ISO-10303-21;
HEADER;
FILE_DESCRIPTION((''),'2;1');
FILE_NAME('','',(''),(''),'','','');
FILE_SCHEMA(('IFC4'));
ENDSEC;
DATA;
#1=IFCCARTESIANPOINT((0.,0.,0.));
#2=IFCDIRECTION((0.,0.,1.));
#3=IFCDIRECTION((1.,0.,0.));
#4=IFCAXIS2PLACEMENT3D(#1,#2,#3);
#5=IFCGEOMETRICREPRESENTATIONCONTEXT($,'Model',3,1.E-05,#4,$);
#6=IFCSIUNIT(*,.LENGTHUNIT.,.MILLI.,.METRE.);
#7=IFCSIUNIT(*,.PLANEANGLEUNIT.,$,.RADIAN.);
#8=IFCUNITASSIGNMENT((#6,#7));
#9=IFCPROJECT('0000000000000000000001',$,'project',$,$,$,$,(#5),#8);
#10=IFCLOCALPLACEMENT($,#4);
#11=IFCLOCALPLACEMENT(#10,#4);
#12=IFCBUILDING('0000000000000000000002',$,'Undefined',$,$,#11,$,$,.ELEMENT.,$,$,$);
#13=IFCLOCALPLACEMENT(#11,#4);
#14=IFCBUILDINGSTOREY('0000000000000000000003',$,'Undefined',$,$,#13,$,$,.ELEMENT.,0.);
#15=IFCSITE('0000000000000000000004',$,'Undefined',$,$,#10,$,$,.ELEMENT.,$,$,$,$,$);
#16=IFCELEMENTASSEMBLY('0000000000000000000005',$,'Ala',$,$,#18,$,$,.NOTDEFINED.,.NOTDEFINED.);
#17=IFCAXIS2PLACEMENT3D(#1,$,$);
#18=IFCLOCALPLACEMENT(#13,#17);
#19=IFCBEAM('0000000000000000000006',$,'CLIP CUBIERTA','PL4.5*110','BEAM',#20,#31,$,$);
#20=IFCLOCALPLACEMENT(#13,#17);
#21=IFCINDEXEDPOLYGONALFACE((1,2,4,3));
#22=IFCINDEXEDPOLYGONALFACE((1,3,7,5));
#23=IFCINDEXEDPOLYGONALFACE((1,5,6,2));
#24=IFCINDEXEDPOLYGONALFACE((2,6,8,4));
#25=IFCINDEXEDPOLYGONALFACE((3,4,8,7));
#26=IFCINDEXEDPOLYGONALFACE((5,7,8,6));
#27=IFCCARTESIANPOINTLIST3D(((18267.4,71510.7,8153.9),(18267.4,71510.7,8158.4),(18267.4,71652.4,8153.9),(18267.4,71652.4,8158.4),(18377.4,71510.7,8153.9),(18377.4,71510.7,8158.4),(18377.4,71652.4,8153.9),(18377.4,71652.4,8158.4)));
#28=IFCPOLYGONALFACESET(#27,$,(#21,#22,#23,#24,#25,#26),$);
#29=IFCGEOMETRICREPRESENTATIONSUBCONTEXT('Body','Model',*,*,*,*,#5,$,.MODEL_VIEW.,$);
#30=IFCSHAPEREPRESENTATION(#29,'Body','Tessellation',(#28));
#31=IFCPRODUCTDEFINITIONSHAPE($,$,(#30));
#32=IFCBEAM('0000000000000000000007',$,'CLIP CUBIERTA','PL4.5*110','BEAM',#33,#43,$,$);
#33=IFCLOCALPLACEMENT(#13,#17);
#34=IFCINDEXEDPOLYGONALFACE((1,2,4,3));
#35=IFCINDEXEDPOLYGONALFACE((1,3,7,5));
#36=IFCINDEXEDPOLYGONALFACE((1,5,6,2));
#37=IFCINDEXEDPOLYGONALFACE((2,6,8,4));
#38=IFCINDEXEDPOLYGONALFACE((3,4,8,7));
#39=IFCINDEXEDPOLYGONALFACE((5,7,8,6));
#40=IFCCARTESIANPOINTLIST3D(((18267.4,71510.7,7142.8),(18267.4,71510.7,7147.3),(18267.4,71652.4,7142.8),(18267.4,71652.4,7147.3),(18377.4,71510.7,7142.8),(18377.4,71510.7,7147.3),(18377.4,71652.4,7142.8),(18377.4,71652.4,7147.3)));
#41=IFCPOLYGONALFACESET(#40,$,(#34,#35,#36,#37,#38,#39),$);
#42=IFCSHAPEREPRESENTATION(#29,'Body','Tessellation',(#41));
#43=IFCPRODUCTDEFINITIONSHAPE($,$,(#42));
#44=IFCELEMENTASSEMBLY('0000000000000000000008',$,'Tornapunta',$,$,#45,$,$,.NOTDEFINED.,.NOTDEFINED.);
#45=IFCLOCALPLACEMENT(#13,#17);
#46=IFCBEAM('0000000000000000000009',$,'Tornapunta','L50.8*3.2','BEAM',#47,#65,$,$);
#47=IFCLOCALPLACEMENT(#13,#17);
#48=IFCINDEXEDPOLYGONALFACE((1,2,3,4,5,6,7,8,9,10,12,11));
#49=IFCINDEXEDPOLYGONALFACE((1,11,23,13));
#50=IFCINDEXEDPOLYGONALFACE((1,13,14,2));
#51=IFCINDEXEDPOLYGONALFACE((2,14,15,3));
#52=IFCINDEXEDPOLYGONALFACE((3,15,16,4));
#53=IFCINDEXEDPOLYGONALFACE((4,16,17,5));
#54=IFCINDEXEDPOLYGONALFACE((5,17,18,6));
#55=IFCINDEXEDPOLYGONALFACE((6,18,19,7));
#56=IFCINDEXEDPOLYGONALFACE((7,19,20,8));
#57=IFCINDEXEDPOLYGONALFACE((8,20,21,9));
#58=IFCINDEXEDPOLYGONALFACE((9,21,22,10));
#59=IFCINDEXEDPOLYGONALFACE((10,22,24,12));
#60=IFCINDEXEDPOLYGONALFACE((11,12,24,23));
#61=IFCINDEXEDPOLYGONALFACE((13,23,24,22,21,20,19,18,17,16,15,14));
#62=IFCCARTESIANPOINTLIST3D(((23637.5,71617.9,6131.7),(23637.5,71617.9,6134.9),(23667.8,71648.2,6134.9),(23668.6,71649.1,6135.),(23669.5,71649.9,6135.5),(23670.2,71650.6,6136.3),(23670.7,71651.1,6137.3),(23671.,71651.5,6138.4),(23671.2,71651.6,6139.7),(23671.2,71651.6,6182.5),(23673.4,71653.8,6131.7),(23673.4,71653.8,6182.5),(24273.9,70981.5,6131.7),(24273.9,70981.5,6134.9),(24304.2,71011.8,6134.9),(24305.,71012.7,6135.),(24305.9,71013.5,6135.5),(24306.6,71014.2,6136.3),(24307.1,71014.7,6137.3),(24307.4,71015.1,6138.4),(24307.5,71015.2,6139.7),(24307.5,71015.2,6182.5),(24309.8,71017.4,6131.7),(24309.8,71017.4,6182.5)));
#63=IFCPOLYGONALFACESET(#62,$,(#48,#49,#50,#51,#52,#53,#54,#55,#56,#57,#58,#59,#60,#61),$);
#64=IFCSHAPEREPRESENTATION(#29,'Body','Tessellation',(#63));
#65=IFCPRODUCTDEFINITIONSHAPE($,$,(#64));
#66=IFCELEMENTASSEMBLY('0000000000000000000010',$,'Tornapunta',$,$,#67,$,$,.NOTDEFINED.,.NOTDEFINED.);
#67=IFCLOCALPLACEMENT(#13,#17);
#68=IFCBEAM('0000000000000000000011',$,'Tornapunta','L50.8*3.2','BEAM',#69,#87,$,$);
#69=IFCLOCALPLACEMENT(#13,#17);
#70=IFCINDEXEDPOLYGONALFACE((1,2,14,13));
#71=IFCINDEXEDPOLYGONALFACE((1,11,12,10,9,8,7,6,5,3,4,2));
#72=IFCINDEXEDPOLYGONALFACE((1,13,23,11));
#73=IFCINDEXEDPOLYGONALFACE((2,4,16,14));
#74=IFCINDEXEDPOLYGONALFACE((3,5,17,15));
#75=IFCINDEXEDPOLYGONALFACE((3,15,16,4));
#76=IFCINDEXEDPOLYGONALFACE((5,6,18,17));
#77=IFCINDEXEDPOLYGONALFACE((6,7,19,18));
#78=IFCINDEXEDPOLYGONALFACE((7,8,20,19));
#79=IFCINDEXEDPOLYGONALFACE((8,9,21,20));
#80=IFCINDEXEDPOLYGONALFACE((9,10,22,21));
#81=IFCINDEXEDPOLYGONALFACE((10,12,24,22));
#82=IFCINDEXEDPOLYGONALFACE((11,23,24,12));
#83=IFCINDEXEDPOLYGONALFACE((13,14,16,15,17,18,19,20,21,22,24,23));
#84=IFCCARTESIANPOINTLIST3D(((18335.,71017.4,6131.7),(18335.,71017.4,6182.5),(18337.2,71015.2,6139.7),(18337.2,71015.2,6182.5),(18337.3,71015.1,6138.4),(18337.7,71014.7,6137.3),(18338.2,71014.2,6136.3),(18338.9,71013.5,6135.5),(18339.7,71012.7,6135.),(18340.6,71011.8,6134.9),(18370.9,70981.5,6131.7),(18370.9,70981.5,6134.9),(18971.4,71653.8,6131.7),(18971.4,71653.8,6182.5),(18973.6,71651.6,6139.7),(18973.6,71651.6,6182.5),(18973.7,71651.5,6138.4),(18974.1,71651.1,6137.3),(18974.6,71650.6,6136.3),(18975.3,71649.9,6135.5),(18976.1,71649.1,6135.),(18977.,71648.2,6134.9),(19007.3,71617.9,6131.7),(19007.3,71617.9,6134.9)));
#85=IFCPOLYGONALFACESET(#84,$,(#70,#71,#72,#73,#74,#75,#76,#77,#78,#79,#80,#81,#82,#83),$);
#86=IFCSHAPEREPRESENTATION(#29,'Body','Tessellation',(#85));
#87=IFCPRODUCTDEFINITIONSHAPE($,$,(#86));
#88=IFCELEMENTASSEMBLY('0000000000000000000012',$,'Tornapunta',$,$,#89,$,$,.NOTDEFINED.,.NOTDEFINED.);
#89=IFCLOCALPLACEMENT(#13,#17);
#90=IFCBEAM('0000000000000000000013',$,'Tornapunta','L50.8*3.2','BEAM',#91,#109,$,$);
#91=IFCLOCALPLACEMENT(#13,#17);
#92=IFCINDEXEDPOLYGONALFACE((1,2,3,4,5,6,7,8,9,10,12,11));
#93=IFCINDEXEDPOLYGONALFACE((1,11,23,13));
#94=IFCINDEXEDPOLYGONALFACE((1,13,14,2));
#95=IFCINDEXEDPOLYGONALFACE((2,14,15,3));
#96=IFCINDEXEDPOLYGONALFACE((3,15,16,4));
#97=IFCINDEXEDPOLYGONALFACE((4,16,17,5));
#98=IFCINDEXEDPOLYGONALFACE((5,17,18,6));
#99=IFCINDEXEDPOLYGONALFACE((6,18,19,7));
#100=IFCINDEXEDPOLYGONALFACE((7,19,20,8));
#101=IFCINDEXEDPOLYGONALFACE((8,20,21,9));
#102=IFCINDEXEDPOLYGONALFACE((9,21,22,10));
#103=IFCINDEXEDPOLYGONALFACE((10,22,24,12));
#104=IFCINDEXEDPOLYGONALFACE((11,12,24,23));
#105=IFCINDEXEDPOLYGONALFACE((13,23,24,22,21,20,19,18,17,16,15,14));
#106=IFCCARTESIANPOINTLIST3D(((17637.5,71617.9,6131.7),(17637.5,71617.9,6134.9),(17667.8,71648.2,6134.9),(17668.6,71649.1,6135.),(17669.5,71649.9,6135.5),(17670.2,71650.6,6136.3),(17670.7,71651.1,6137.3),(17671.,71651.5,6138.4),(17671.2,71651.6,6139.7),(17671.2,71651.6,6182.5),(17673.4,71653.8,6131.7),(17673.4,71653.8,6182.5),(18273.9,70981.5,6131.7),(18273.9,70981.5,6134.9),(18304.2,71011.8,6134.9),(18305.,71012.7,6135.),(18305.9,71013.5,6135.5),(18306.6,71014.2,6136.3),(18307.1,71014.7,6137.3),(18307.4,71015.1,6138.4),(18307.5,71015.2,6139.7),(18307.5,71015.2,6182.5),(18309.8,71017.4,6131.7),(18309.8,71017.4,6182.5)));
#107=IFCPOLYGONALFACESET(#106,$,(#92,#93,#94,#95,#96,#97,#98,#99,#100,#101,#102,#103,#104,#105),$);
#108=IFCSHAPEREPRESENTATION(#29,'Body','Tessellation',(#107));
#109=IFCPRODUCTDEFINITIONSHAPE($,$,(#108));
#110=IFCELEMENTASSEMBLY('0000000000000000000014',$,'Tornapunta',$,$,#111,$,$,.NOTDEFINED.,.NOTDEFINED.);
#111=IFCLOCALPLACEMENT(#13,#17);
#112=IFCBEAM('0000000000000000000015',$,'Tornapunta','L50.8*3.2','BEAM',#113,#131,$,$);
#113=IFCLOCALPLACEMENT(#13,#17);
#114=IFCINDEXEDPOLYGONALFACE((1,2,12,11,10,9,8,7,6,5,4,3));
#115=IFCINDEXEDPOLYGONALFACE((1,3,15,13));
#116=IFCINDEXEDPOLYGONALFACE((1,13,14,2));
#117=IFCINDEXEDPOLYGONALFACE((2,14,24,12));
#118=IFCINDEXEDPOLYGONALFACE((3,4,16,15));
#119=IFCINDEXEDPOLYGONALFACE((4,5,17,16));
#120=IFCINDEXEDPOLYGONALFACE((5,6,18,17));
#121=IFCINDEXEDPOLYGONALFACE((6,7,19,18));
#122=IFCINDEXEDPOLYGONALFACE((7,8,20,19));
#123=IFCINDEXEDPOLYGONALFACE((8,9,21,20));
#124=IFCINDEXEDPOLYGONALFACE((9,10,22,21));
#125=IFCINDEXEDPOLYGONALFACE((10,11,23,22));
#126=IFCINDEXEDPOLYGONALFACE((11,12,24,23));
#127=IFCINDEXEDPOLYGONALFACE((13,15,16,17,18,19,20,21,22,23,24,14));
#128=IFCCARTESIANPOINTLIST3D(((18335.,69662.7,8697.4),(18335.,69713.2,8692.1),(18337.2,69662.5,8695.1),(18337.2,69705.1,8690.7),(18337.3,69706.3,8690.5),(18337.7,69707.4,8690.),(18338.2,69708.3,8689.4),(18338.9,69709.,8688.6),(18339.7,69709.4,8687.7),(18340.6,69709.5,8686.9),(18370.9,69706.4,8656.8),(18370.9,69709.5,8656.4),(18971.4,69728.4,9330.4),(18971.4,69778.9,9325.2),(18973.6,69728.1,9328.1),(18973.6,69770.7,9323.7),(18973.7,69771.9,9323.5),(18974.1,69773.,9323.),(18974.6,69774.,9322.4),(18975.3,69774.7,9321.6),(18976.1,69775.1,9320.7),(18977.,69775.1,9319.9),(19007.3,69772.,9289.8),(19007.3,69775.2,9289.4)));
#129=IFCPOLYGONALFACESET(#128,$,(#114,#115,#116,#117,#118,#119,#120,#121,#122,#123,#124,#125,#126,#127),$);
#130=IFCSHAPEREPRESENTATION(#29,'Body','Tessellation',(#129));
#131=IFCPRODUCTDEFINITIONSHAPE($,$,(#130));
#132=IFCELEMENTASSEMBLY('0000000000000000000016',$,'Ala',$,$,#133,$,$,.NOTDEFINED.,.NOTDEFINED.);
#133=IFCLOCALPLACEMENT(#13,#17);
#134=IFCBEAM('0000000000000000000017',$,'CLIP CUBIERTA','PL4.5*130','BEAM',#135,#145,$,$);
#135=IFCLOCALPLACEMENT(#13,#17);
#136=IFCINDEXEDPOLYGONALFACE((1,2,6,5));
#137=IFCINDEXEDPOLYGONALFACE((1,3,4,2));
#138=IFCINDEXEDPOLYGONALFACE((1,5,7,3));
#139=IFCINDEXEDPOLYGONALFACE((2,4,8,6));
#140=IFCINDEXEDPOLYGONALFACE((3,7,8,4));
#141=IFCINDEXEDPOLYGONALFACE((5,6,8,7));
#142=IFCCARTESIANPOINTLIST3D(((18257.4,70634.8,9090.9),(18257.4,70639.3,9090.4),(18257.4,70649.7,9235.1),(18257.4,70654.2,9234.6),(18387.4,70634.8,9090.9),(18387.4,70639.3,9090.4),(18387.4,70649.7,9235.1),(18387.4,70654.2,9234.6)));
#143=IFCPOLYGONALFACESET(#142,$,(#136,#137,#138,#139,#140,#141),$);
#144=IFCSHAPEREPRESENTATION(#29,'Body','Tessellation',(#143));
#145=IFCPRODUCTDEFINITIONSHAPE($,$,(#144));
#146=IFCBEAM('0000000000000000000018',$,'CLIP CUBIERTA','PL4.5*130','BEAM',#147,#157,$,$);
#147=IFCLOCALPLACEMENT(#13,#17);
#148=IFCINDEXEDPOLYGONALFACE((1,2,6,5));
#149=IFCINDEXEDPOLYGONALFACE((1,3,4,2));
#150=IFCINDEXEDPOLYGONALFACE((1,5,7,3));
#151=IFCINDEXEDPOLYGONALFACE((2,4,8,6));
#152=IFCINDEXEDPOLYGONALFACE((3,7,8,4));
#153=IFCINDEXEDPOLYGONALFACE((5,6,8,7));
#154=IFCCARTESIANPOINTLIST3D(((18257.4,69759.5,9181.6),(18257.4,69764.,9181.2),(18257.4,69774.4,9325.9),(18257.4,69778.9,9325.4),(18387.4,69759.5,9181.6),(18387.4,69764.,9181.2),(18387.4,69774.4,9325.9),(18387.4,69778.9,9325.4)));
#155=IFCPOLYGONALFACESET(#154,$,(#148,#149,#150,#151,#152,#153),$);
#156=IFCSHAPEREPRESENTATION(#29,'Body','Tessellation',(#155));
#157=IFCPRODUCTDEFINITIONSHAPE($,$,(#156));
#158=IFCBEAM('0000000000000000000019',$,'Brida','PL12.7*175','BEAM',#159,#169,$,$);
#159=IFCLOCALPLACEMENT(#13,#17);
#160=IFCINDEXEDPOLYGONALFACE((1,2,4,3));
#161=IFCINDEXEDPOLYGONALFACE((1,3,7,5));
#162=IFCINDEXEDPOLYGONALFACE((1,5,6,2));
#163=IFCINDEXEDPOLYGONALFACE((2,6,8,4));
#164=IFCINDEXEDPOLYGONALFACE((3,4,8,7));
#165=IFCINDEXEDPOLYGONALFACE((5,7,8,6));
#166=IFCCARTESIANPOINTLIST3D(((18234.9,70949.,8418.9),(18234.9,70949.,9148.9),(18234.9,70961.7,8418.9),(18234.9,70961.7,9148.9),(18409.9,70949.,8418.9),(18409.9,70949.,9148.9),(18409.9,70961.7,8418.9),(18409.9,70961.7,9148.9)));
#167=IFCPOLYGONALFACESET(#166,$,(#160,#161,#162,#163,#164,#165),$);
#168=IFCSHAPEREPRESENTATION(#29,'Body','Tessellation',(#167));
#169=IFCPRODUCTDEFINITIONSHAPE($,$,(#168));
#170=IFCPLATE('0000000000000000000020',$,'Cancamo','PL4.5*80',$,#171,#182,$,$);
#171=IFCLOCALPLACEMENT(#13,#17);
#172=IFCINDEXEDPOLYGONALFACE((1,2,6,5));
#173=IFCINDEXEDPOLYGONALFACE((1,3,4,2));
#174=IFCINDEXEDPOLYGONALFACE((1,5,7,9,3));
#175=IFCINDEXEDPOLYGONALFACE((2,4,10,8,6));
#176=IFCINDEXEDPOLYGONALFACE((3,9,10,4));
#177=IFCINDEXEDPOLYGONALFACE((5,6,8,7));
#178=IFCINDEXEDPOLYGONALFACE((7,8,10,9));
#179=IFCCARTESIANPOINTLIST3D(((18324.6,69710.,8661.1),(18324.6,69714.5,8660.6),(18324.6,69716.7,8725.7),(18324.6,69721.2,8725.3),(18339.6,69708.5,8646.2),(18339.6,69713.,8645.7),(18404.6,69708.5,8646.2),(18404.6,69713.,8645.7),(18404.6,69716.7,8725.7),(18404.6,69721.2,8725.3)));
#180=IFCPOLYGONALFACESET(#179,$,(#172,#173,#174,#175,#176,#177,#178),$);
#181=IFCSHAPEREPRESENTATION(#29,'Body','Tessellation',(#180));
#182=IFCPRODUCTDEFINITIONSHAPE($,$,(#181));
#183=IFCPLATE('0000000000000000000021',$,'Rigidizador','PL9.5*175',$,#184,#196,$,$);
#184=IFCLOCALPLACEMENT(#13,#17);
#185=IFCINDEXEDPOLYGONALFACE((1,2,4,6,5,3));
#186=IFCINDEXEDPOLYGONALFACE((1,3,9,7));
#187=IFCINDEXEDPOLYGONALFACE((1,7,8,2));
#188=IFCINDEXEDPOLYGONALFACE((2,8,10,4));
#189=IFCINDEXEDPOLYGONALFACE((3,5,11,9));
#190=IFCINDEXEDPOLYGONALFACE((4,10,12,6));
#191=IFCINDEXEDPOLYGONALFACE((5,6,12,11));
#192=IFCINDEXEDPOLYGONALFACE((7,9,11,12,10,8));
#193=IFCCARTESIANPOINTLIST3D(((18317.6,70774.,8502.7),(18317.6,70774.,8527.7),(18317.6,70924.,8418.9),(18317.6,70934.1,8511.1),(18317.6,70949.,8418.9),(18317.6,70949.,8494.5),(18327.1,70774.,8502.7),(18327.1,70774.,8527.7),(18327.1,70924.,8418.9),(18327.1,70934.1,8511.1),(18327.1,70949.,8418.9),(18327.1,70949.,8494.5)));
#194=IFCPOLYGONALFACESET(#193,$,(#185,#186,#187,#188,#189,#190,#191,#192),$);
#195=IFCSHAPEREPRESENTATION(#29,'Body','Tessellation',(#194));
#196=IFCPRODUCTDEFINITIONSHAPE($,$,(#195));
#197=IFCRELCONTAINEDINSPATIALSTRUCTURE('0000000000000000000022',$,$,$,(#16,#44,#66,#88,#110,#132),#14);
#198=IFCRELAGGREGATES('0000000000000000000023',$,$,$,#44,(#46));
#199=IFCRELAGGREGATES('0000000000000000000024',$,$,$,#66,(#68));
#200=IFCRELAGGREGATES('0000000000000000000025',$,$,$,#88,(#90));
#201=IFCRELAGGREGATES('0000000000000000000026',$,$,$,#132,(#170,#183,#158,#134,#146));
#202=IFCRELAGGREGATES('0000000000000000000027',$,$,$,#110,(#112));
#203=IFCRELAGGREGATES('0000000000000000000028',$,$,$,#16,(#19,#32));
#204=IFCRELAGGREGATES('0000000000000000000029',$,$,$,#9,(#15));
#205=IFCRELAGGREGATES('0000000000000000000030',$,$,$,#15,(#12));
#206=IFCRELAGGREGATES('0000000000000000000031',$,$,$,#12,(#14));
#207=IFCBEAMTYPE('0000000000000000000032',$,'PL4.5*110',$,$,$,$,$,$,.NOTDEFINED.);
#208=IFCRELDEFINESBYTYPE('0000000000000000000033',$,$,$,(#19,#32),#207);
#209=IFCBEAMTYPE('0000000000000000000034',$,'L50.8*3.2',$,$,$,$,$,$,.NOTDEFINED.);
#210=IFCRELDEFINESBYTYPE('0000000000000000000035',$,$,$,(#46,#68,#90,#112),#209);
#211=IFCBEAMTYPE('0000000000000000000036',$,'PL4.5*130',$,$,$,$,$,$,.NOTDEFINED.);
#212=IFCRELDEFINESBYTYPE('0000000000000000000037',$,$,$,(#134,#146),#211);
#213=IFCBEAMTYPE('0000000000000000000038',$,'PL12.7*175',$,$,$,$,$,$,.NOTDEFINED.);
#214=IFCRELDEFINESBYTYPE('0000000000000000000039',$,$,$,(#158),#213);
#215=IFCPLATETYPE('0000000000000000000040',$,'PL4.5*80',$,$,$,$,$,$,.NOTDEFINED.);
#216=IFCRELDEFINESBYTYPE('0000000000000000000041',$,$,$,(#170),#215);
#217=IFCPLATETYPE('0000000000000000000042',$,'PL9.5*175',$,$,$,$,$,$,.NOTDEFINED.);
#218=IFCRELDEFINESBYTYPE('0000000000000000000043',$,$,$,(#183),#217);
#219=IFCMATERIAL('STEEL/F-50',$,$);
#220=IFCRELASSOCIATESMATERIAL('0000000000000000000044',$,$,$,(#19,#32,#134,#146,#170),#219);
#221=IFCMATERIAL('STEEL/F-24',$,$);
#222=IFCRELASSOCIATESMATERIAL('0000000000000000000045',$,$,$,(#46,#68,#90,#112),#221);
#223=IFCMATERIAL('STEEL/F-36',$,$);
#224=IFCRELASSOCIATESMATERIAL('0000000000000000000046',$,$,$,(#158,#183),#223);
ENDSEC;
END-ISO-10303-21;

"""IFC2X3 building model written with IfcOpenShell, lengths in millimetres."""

from ifc_helpers import new_model, si_unit, frame, origin_with_axes, origin_2d_with_axis, place, context, subcontext, project, spatial, polyline, rectangle, l_section, outline, extrude, material, type_object, element, aggregate, save


model = new_model("IFC2X3")

# Units and contexts
model_context = context("Model", 3, precision=1e-05, world=origin_with_axes())
body_context = subcontext(model_context, "Body", "Model", "MODEL_VIEW")
ifc_project = project(units=[si_unit("LENGTHUNIT", "METRE", prefix="MILLI"), si_unit("PLANEANGLEUNIT", "RADIAN")], contexts=[model_context])

# Site, building, storey
site_placement = place(None, origin_with_axes())
site = spatial("IfcSite", under=ifc_project, at=site_placement, Name="Undefined", CompositionType="ELEMENT")
building_placement = place(site_placement, origin_with_axes())
building = spatial("IfcBuilding", under=site, at=building_placement, Name="Undefined", CompositionType="ELEMENT")
storey_placement = place(building_placement, origin_with_axes())
storey = spatial("IfcBuildingStorey", under=building, at=storey_placement, Name="Undefined", CompositionType="ELEMENT", Elevation=0.0)

# Element assembly, beams
assembly_1_placement = place(storey_placement, origin_with_axes())
assembly_1 = element("IfcElementAssembly", 1, at=assembly_1_placement, inside=storey, Name="Ala", AssemblyPlace="NOTDEFINED", PredefinedType="NOTDEFINED")
ifc_material_1 = material(Name="STEEL/F-50")
beam_type_1 = type_object("IfcBeamType", Name="PL4.5*110", PredefinedType="NOTDEFINED")
beam_1_placement = place(assembly_1_placement, frame((18322.4, 71510.7, 8156.1), z_axis=(1.0, 0.0, 0.0), x_axis=(0.0, 1.0, 0.0)))
beam_1 = element("IfcBeam", 2, at=beam_1_placement, type_object=beam_type_1, material=ifc_material_1, Name="CLIP CUBIERTA", Description="PL4.5*110", ObjectType="BEAM", context=body_context, shape_type="SweptSolid", body=[
    extrude(rectangle(XDim=4.5, YDim=110.0, at=origin_2d_with_axis()), frame((141.7, 0.0, 0.0), z_axis=(-1.0, 0.0, 0.0), x_axis=(0.0, -1.0, 0.0)), (0.0, 0.0, 1.0), 141.7),
])
beam_2_placement = place(assembly_1_placement, frame((18322.4, 71510.7, 7145.0), z_axis=(1.0, 0.0, 0.0), x_axis=(0.0, 1.0, 0.0)))
beam_2 = element("IfcBeam", 3, at=beam_2_placement, type_object=beam_type_1, material=ifc_material_1, Name="CLIP CUBIERTA", Description="PL4.5*110", ObjectType="BEAM", context=body_context, shape_type="SweptSolid", body=[
    extrude(rectangle(XDim=4.5, YDim=110.0, at=origin_2d_with_axis()), frame((141.7, 0.0, 0.0), z_axis=(-1.0, 0.0, 0.0), x_axis=(0.0, -1.0, 0.0)), (0.0, 0.0, 1.0), 141.7),
])

# Element assemblies, beams
assembly_2_placement = place(storey_placement, origin_with_axes())
assembly_2 = element("IfcElementAssembly", 4, at=assembly_2_placement, inside=storey, Name="Tornapunta", AssemblyPlace="NOTDEFINED", PredefinedType="NOTDEFINED")
ifc_material_2 = material(Name="STEEL/F-24")
beam_type_2 = type_object("IfcBeamType", Name="L50.8*3.2", PredefinedType="NOTDEFINED")
beam_3_placement = place(assembly_2_placement, frame((24291.9, 70999.5, 6157.1), z_axis=(-0.707107, -0.707107, 0.000016), x_axis=(-0.707107, 0.707107, -0.000016)))
beam_3 = element("IfcBeam", 5, at=beam_3_placement, type_object=beam_type_2, material=ifc_material_2, Name="Tornapunta", Description="L50.8*3.2", ObjectType="BEAM", context=body_context, shape_type="SweptSolid", body=[
    extrude(l_section(Depth=50.8, Width=50.8, Thickness=3.2, FilletRadius=4.8, at=origin_2d_with_axis()), frame((900.0, 0.0, 0.0), z_axis=(-1.0, 0.0, 0.0), x_axis=(0.0, -1.0, 0.0)), (0.0, 0.0, 1.0), 900.0),
])
aggregate(assembly_2, [beam_3])
assembly_3_placement = place(storey_placement, origin_with_axes())
assembly_3 = element("IfcElementAssembly", 6, at=assembly_3_placement, inside=storey, Name="Tornapunta", AssemblyPlace="NOTDEFINED", PredefinedType="NOTDEFINED")
beam_4_placement = place(assembly_3_placement, frame((18989.3, 71635.9, 6157.1), z_axis=(0.707107, -0.707107, 0.000016), x_axis=(-0.707107, -0.707107, 0.000016)))
beam_4 = element("IfcBeam", 7, at=beam_4_placement, type_object=beam_type_2, material=ifc_material_2, Name="Tornapunta", Description="L50.8*3.2", ObjectType="BEAM", context=body_context, shape_type="SweptSolid", body=[
    extrude(l_section(Depth=50.8, Width=50.8, Thickness=3.2, FilletRadius=4.8, at=origin_2d_with_axis()), frame((900.0, 0.0, 0.0), z_axis=(-1.0, 0.0, 0.0), x_axis=(0.0, -1.0, 0.0)), (0.0, 0.0, 1.0), 900.0),
])
aggregate(assembly_3, [beam_4])
assembly_4_placement = place(storey_placement, origin_with_axes())
assembly_4 = element("IfcElementAssembly", 8, at=assembly_4_placement, inside=storey, Name="Tornapunta", AssemblyPlace="NOTDEFINED", PredefinedType="NOTDEFINED")
beam_5_placement = place(assembly_4_placement, frame((18291.9, 70999.5, 6157.1), z_axis=(-0.707107, -0.707107, 0.000016), x_axis=(-0.707107, 0.707107, -0.000016)))
beam_5 = element("IfcBeam", 9, at=beam_5_placement, type_object=beam_type_2, material=ifc_material_2, Name="Tornapunta", Description="L50.8*3.2", ObjectType="BEAM", context=body_context, shape_type="SweptSolid", body=[
    extrude(l_section(Depth=50.8, Width=50.8, Thickness=3.2, FilletRadius=4.8, at=origin_2d_with_axis()), frame((900.0, 0.0, 0.0), z_axis=(-1.0, 0.0, 0.0), x_axis=(0.0, -1.0, 0.0)), (0.0, 0.0, 1.0), 900.0),
])
aggregate(assembly_4, [beam_5])
assembly_5_placement = place(storey_placement, origin_with_axes())
assembly_5 = element("IfcElementAssembly", 10, at=assembly_5_placement, inside=storey, Name="Tornapunta", AssemblyPlace="NOTDEFINED", PredefinedType="NOTDEFINED")
beam_6_placement = place(assembly_5_placement, frame((18989.3, 69751.8, 9309.9), z_axis=(0.707107, -0.072947, -0.703334), x_axis=(-0.707107, -0.072947, -0.703334)))
beam_6 = element("IfcBeam", 11, at=beam_6_placement, type_object=beam_type_2, material=ifc_material_2, Name="Tornapunta", Description="L50.8*3.2", ObjectType="BEAM", context=body_context, shape_type="SweptSolid", body=[
    extrude(l_section(Depth=50.8, Width=50.8, Thickness=3.2, FilletRadius=4.8, at=origin_2d_with_axis()), frame((900.0, 0.0, 0.0), z_axis=(-1.0, 0.0, 0.0), x_axis=(0.0, -1.0, 0.0)), (0.0, 0.0, 1.0), 900.0),
])

# Element assembly, beams, plates
assembly_6_placement = place(storey_placement, origin_with_axes())
assembly_6 = element("IfcElementAssembly", 12, at=assembly_6_placement, inside=storey, Name="Ala", AssemblyPlace="NOTDEFINED", PredefinedType="NOTDEFINED")
beam_type_3 = type_object("IfcBeamType", Name="PL4.5*130", PredefinedType="NOTDEFINED")
beam_7_placement = place(assembly_6_placement, frame((18322.4, 70637.0, 9090.6), z_axis=(-1.0, 0.0, 0.0), x_axis=(0.0, 0.103162, 0.994665)))
beam_7 = element("IfcBeam", 13, at=beam_7_placement, type_object=beam_type_3, material=ifc_material_1, Name="CLIP CUBIERTA", Description="PL4.5*130", ObjectType="BEAM", context=body_context, shape_type="SweptSolid", body=[
    extrude(rectangle(XDim=4.5, YDim=130.0, at=origin_2d_with_axis()), frame((145.0, 0.0, 0.0), z_axis=(-1.0, 0.0, 0.0), x_axis=(0.0, -1.0, 0.0)), (0.0, 0.0, 1.0), 145.0),
])
beam_8_placement = place(assembly_6_placement, frame((18322.4, 69761.7, 9181.4), z_axis=(-1.0, 0.0, 0.0), x_axis=(0.0, 0.103162, 0.994665)))
beam_8 = element("IfcBeam", 14, at=beam_8_placement, type_object=beam_type_3, material=ifc_material_1, Name="CLIP CUBIERTA", Description="PL4.5*130", ObjectType="BEAM", context=body_context, shape_type="SweptSolid", body=[
    extrude(rectangle(XDim=4.5, YDim=130.0, at=origin_2d_with_axis()), frame((145.0, 0.0, 0.0), z_axis=(-1.0, 0.0, 0.0), x_axis=(0.0, -1.0, 0.0)), (0.0, 0.0, 1.0), 145.0),
])
ifc_material_3 = material(Name="STEEL/F-36")
beam_type_4 = type_object("IfcBeamType", Name="PL12.7*175", PredefinedType="NOTDEFINED")
beam_9_placement = place(assembly_6_placement, frame((18322.4, 70955.3, 8418.9), z_axis=(1.0, 0.0, 0.0), x_axis=(0.0, 0.0, 1.0)))
beam_9 = element("IfcBeam", 15, at=beam_9_placement, type_object=beam_type_4, material=ifc_material_3, Name="Brida", Description="PL12.7*175", ObjectType="BEAM", context=body_context, shape_type="SweptSolid", body=[
    extrude(rectangle(XDim=12.7, YDim=175.0, at=origin_2d_with_axis()), frame((730.0, 0.0, 0.0), z_axis=(-1.0, 0.0, 0.0), x_axis=(0.0, -1.0, 0.0)), (0.0, 0.0, 1.0), 730.0),
])
plate_type_1 = type_object("IfcPlateType", Name="PL4.5*80", PredefinedType="NOTDEFINED")
plate_1_placement = place(assembly_6_placement, frame((18404.6, 69710.7, 8645.9), z_axis=(0.0, 0.994665, -0.103162), x_axis=(-1.0, 0.0, 0.0)))
plate_1 = element("IfcPlate", 16, at=plate_1_placement, type_object=plate_type_1, material=ifc_material_1, Name="Cancamo", Description="PL4.5*80", context=body_context, shape_type="SweptSolid", body=[
    extrude(outline(polyline([(0.0, 0.0), (65.0, 0.0), (80.0, 15.0), (80.0, 80.0), (0.0, 80.0), (0.0, 0.0)])), frame((0.0, 0.0, -2.2), z_axis=(0.0, 0.0, 1.0), x_axis=(1.0, 0.0, 0.0)), (0.0, 0.0, 1.0), 4.5),
])
plate_type_2 = type_object("IfcPlateType", Name="PL9.5*175", PredefinedType="NOTDEFINED")
plate_2_placement = place(assembly_6_placement, frame((18322.4, 70924.0, 8418.9), z_axis=(1.0, 0.0, 0.0), x_axis=(0.0, 1.0, 0.0)))
plate_2 = element("IfcPlate", 17, at=plate_2_placement, type_object=plate_type_2, material=ifc_material_3, Name="Rigidizador", Description="PL9.5*175", context=body_context, shape_type="SweptSolid", body=[
    extrude(outline(polyline([(0.0, 0.0), (25.0, 0.0), (25.0, 75.6), (10.1, 92.2), (-150.0, 108.8), (-150.0, 83.8), (0.0, 0.0)])), frame((0.0, 0.0, -4.8), z_axis=(0.0, 0.0, 1.0), x_axis=(1.0, 0.0, 0.0)), (0.0, 0.0, 1.0), 9.5),
])
aggregate(assembly_6, [plate_1, plate_2, beam_9, beam_7, beam_8])

aggregate(assembly_5, [beam_6])

aggregate(assembly_1, [beam_1, beam_2])

save(model, "model.ifc")
